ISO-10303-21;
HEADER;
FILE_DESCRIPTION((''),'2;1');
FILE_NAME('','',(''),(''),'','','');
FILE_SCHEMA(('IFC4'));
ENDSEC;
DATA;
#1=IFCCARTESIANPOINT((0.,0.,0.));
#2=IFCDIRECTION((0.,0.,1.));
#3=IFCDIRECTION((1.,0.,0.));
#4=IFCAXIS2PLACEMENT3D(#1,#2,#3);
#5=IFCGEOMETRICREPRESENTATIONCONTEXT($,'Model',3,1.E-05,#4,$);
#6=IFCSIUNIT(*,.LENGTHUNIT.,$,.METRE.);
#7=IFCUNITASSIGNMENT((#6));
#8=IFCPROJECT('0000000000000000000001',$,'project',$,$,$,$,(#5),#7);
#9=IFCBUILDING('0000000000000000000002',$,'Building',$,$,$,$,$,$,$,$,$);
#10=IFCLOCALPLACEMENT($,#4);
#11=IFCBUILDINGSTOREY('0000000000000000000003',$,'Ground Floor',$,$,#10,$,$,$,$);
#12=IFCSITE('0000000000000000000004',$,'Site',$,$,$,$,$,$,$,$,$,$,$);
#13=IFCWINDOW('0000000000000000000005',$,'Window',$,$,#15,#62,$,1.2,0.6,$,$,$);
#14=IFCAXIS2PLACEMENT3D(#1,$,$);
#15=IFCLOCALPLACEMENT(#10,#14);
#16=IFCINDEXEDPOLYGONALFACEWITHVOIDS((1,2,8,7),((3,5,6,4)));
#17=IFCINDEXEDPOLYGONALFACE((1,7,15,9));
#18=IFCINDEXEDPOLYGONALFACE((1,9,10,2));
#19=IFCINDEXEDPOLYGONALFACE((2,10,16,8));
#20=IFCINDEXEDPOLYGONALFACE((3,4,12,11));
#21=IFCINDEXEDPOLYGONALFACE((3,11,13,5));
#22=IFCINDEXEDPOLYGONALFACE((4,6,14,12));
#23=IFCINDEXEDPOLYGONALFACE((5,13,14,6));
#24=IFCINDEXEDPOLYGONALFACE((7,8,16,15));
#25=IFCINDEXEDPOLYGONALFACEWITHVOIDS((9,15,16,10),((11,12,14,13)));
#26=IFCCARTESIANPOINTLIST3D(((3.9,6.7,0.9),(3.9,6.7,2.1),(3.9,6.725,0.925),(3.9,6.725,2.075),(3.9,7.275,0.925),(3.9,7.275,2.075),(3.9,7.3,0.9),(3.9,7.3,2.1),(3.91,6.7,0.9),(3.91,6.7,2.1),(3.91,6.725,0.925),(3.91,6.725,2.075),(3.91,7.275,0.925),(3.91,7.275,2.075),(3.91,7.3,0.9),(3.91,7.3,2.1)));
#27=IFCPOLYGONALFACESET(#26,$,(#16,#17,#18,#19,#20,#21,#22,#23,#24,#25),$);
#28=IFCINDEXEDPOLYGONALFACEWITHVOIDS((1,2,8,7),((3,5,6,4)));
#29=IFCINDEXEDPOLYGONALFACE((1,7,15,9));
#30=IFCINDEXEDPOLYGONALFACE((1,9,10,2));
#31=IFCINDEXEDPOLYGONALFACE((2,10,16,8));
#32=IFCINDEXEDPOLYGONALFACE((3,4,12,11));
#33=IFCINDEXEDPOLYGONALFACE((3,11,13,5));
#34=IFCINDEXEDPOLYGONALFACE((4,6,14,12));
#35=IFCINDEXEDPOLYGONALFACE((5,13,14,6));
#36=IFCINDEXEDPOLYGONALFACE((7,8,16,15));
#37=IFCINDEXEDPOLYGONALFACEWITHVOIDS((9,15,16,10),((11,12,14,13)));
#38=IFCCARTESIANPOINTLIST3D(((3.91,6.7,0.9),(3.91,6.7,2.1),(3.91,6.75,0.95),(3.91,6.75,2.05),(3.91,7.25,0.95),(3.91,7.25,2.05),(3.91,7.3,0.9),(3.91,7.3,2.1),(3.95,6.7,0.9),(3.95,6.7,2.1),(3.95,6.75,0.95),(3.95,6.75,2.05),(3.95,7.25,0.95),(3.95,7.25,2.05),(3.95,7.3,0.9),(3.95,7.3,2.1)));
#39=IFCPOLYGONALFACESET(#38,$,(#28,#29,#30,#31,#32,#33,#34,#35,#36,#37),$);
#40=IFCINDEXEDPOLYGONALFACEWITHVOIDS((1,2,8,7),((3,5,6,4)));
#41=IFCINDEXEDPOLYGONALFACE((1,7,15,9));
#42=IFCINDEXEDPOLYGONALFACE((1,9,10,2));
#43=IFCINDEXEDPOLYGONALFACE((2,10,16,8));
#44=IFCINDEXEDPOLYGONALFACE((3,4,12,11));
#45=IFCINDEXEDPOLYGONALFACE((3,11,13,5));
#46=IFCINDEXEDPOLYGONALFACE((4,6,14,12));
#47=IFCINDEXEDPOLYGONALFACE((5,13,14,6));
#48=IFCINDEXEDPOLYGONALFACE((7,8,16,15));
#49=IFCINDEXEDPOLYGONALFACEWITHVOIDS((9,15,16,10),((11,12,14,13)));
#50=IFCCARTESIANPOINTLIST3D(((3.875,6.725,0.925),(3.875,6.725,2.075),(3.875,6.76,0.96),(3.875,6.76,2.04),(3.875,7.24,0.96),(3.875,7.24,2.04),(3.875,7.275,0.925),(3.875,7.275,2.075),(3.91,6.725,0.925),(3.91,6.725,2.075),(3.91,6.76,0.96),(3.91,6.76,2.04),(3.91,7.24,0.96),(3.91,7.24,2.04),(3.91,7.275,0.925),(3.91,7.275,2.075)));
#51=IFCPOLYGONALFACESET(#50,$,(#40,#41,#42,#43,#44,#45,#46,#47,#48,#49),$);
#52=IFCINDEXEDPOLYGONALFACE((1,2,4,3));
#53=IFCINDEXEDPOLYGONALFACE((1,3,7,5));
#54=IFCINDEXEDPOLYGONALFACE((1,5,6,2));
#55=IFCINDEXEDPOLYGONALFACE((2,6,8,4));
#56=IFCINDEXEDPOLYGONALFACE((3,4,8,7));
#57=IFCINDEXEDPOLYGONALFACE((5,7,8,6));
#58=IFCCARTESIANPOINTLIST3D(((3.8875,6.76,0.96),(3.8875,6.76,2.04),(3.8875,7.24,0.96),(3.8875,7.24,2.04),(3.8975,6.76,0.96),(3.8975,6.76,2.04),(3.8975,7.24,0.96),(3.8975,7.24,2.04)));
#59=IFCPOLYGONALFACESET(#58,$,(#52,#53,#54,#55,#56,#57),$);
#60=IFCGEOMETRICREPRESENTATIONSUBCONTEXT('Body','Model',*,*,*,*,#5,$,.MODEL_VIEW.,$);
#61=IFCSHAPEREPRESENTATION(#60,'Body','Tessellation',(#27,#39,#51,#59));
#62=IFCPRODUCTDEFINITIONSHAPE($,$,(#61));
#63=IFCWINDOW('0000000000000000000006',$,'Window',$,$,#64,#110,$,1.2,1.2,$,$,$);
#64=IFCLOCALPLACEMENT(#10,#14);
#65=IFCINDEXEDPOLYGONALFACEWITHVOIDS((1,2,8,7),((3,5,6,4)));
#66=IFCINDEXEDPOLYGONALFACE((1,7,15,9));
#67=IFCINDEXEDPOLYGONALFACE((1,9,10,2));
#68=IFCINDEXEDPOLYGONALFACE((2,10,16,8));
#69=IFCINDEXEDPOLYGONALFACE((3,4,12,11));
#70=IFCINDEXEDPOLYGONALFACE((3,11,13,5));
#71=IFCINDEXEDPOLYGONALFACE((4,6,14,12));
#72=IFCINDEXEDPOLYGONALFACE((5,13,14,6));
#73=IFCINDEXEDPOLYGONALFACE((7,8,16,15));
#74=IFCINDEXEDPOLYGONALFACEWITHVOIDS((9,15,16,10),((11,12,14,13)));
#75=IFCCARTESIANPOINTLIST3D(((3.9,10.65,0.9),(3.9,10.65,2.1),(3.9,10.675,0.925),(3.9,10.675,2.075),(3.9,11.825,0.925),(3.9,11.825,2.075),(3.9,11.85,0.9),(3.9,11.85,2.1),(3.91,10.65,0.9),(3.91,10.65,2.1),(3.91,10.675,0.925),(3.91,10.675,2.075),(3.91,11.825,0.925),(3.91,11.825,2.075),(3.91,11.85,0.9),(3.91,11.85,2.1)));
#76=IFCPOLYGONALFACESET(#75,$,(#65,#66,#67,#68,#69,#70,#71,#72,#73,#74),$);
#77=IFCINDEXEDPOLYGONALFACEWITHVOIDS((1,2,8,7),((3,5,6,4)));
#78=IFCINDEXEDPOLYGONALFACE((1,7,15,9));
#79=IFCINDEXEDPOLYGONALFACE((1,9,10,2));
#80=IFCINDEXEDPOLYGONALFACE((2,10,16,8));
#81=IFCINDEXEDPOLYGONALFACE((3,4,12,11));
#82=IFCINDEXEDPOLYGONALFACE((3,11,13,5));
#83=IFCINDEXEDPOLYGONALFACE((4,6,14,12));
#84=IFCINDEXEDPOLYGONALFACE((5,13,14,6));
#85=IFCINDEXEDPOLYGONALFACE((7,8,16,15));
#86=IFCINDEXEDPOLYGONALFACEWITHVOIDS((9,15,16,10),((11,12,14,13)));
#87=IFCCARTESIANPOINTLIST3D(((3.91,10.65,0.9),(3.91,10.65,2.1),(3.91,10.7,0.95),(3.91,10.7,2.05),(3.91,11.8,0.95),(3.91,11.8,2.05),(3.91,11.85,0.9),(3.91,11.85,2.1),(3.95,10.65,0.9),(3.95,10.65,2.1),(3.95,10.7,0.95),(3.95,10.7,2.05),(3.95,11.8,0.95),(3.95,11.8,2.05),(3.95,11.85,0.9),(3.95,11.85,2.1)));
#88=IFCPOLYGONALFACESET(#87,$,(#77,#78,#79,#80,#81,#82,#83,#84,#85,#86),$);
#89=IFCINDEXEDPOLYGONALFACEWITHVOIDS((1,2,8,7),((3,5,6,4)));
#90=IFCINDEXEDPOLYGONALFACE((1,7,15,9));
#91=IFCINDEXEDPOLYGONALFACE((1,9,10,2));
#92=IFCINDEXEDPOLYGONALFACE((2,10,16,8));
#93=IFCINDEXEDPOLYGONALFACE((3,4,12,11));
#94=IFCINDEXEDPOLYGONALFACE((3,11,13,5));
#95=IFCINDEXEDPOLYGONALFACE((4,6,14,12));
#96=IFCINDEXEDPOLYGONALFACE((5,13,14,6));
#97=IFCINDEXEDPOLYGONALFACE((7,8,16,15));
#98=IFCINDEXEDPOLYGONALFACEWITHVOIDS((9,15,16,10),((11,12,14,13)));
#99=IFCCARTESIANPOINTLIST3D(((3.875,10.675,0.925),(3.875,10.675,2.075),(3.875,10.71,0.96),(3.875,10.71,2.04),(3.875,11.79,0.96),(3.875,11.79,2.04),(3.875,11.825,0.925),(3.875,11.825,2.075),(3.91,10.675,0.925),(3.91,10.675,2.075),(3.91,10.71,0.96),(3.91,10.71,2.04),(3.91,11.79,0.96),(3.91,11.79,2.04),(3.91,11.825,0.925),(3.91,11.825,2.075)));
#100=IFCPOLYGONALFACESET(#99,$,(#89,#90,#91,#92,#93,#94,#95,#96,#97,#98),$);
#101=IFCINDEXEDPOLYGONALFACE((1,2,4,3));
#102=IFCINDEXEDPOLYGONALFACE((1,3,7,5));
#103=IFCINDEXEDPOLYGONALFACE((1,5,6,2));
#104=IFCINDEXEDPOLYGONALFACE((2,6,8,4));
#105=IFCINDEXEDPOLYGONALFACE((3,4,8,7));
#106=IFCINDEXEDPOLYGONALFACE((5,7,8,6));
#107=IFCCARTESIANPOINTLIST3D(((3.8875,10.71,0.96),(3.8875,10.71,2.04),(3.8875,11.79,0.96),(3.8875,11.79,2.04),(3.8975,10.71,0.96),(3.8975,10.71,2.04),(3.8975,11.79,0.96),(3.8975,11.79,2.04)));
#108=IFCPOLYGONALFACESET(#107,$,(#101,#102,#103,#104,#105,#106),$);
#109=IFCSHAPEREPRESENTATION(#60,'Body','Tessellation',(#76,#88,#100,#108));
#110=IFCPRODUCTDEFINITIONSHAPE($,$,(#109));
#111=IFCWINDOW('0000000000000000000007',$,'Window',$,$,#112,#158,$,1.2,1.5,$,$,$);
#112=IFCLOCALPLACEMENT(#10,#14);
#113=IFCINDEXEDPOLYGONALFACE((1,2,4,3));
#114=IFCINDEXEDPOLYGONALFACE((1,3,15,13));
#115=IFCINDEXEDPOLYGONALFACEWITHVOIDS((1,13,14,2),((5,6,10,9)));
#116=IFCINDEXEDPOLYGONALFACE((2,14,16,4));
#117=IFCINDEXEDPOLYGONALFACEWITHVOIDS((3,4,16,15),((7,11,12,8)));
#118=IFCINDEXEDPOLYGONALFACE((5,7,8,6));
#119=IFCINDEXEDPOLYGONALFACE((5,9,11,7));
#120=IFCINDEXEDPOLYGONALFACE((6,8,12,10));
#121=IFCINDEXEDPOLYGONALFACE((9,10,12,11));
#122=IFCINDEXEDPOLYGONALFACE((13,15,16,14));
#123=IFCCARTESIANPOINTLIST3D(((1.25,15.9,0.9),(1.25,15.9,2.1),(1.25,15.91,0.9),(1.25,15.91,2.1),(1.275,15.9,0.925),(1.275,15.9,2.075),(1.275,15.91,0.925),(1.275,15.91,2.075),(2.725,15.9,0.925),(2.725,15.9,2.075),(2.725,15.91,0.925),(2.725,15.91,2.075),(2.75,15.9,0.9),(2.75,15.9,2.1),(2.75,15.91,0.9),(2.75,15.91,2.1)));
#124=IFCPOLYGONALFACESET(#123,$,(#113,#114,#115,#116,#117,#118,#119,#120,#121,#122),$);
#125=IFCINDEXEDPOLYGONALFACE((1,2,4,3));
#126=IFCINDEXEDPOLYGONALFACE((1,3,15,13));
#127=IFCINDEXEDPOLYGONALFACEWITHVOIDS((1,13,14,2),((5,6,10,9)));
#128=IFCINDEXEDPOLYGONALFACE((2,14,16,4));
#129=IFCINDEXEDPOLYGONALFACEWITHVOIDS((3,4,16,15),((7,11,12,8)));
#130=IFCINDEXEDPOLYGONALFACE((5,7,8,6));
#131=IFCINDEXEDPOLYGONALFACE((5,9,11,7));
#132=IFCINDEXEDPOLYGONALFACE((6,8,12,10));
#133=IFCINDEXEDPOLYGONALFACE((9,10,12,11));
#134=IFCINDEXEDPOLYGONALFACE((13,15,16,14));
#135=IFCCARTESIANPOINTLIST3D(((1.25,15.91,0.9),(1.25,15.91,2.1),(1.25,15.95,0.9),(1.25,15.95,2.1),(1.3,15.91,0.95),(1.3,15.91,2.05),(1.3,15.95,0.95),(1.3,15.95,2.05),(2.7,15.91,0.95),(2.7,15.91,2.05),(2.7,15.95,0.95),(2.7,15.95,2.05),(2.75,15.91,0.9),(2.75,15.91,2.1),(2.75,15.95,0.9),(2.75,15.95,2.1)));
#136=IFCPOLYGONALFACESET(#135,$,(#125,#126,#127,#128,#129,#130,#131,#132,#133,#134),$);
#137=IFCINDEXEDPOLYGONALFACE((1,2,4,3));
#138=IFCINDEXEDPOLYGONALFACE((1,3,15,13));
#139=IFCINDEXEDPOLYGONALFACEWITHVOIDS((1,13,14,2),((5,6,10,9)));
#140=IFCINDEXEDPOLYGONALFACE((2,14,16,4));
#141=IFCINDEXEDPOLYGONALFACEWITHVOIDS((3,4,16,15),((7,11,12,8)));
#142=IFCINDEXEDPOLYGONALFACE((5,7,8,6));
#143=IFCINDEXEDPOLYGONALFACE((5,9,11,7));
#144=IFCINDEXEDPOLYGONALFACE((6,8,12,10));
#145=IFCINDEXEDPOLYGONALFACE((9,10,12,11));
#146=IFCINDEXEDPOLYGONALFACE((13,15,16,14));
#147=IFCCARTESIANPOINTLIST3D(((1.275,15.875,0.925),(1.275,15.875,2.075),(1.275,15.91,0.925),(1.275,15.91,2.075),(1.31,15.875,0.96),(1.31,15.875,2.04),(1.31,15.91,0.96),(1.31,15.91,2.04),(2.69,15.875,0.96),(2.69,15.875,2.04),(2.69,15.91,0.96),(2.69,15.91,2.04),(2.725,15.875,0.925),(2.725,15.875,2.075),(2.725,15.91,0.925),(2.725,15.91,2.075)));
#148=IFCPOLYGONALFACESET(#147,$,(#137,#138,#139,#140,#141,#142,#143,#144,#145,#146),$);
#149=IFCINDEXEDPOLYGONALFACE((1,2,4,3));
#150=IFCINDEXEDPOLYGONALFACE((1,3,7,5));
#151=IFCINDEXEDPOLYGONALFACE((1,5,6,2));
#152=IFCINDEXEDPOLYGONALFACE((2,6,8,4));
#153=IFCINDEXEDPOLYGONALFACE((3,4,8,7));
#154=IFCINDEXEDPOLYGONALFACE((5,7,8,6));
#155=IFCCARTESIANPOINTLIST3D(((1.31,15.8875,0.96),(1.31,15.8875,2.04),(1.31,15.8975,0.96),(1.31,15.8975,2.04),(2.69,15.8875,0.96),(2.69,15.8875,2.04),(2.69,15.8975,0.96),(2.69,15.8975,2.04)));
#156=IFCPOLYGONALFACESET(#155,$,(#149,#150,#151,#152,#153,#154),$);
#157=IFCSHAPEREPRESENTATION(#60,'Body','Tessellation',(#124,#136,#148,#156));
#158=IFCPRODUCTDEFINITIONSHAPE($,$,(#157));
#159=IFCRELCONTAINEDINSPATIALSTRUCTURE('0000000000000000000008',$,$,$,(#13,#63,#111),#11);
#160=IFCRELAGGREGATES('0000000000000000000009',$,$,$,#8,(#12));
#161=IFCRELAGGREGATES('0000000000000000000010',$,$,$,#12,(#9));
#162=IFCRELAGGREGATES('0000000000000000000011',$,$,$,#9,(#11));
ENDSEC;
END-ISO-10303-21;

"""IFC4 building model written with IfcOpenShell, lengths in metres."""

from ifc_helpers import new_model, si_unit, frame, origin_with_axes, place, context, subcontext, project, spatial, line, indexed_curve, outline, extrude, element, save


model = new_model("IFC4")

# Units and contexts
model_context = context("Model", 3, precision=1e-05, world=origin_with_axes())
body_context = subcontext(model_context, "Body", "Model", "MODEL_VIEW")
ifc_project = project(units=[si_unit("LENGTHUNIT", "METRE")], contexts=[model_context])

# Site, building, storey
site = spatial("IfcSite", under=ifc_project, Name="Site")
building = spatial("IfcBuilding", under=site, Name="Building")
storey_placement = place(None, origin_with_axes())
storey = spatial("IfcBuildingStorey", under=building, at=storey_placement, Name="Ground Floor")

# Windows
window_1_placement = place(storey_placement, frame((4.0, 6.7, 0.9), z_axis=(0.0, 0.0, 1.0), x_axis=(0.0, 1.0, 0.0)))
element("IfcWindow", 1, at=window_1_placement, inside=storey, Name="Window", OverallHeight=1.2, OverallWidth=0.6, context=body_context, shape_type="SweptSolid", body=[
    extrude(outline(indexed_curve([(0.0, 0.0), (0.6, 0.0), (0.6, 1.2), (0.0, 1.2)], segments=[line(1, 2, 3, 4, 1)]), holes=[indexed_curve([(0.025, 0.025), (0.575, 0.025), (0.575, 1.175), (0.025, 1.175)], segments=[line(1, 2, 3, 4, 1)])]), frame((0.0, 0.09, 0.0), z_axis=(0.0, -1.0, 0.0), x_axis=(1.0, 0.0, 0.0)), (0.0, 0.0, -1.0), 0.01),
    extrude(outline(indexed_curve([(0.0, 0.0), (0.6, 0.0), (0.6, 1.2), (0.0, 1.2)], segments=[line(1, 2, 3, 4, 1)]), holes=[indexed_curve([(0.05, 0.05), (0.55, 0.05), (0.55, 1.15), (0.05, 1.15)], segments=[line(1, 2, 3, 4, 1)])]), frame((0.0, 0.05, 0.0), z_axis=(0.0, -1.0, 0.0), x_axis=(1.0, 0.0, 0.0)), (0.0, 0.0, -1.0), 0.04),
    extrude(outline(indexed_curve([(0.0, 0.0), (0.55, 0.0), (0.55, 1.15), (0.0, 1.15)], segments=[line(1, 2, 3, 4, 1)]), holes=[indexed_curve([(0.035, 0.035), (0.515, 0.035), (0.515, 1.115), (0.035, 1.115)], segments=[line(1, 2, 3, 4, 1)])]), frame((0.025, 0.09, 0.025), z_axis=(0.0, -1.0, 0.0), x_axis=(1.0, 0.0, 0.0)), (0.0, 0.0, -1.0), 0.035),
    extrude(outline(indexed_curve([(0.035, 0.035), (0.515, 0.035), (0.515, 1.115), (0.035, 1.115)], segments=[line(1, 2, 3, 4, 1)])), frame((0.025, 0.1025, 0.025), z_axis=(0.0, -1.0, 0.0), x_axis=(1.0, 0.0, 0.0)), (0.0, 0.0, -1.0), 0.01),
])
window_2_placement = place(storey_placement, frame((4.0, 10.65, 0.9), z_axis=(0.0, 0.0, 1.0), x_axis=(0.0, 1.0, 0.0)))
element("IfcWindow", 2, at=window_2_placement, inside=storey, Name="Window", OverallHeight=1.2, OverallWidth=1.2, context=body_context, shape_type="SweptSolid", body=[
    extrude(outline(indexed_curve([(0.0, 0.0), (1.2, 0.0), (1.2, 1.2), (0.0, 1.2)], segments=[line(1, 2, 3, 4, 1)]), holes=[indexed_curve([(0.025, 0.025), (1.175, 0.025), (1.175, 1.175), (0.025, 1.175)], segments=[line(1, 2, 3, 4, 1)])]), frame((0.0, 0.09, 0.0), z_axis=(0.0, -1.0, 0.0), x_axis=(1.0, 0.0, 0.0)), (0.0, 0.0, -1.0), 0.01),
    extrude(outline(indexed_curve([(0.0, 0.0), (1.2, 0.0), (1.2, 1.2), (0.0, 1.2)], segments=[line(1, 2, 3, 4, 1)]), holes=[indexed_curve([(0.05, 0.05), (1.15, 0.05), (1.15, 1.15), (0.05, 1.15)], segments=[line(1, 2, 3, 4, 1)])]), frame((0.0, 0.05, 0.0), z_axis=(0.0, -1.0, 0.0), x_axis=(1.0, 0.0, 0.0)), (0.0, 0.0, -1.0), 0.04),
    extrude(outline(indexed_curve([(0.0, 0.0), (1.15, 0.0), (1.15, 1.15), (0.0, 1.15)], segments=[line(1, 2, 3, 4, 1)]), holes=[indexed_curve([(0.035, 0.035), (1.115, 0.035), (1.115, 1.115), (0.035, 1.115)], segments=[line(1, 2, 3, 4, 1)])]), frame((0.025, 0.09, 0.025), z_axis=(0.0, -1.0, 0.0), x_axis=(1.0, 0.0, 0.0)), (0.0, 0.0, -1.0), 0.035),
    extrude(outline(indexed_curve([(0.035, 0.035), (1.115, 0.035), (1.115, 1.115), (0.035, 1.115)], segments=[line(1, 2, 3, 4, 1)])), frame((0.025, 0.1025, 0.025), z_axis=(0.0, -1.0, 0.0), x_axis=(1.0, 0.0, 0.0)), (0.0, 0.0, -1.0), 0.01),
])
window_3_placement = place(storey_placement, frame((2.75, 16.0, 0.9), z_axis=(0.0, 0.0, 1.0), x_axis=(-1.0, 0.0, 0.0)))
element("IfcWindow", 3, at=window_3_placement, inside=storey, Name="Window", OverallHeight=1.2, OverallWidth=1.5, context=body_context, shape_type="SweptSolid", body=[
    extrude(outline(indexed_curve([(0.0, 0.0), (1.5, 0.0), (1.5, 1.2), (0.0, 1.2)], segments=[line(1, 2, 3, 4, 1)]), holes=[indexed_curve([(0.025, 0.025), (1.475, 0.025), (1.475, 1.175), (0.025, 1.175)], segments=[line(1, 2, 3, 4, 1)])]), frame((0.0, 0.09, 0.0), z_axis=(0.0, -1.0, 0.0), x_axis=(1.0, 0.0, 0.0)), (0.0, 0.0, -1.0), 0.01),
    extrude(outline(indexed_curve([(0.0, 0.0), (1.5, 0.0), (1.5, 1.2), (0.0, 1.2)], segments=[line(1, 2, 3, 4, 1)]), holes=[indexed_curve([(0.05, 0.05), (1.45, 0.05), (1.45, 1.15), (0.05, 1.15)], segments=[line(1, 2, 3, 4, 1)])]), frame((0.0, 0.05, 0.0), z_axis=(0.0, -1.0, 0.0), x_axis=(1.0, 0.0, 0.0)), (0.0, 0.0, -1.0), 0.04),
    extrude(outline(indexed_curve([(0.0, 0.0), (1.45, 0.0), (1.45, 1.15), (0.0, 1.15)], segments=[line(1, 2, 3, 4, 1)]), holes=[indexed_curve([(0.035, 0.035), (1.415, 0.035), (1.415, 1.115), (0.035, 1.115)], segments=[line(1, 2, 3, 4, 1)])]), frame((0.025, 0.09, 0.025), z_axis=(0.0, -1.0, 0.0), x_axis=(1.0, 0.0, 0.0)), (0.0, 0.0, -1.0), 0.035),
    extrude(outline(indexed_curve([(0.035, 0.035), (1.415, 0.035), (1.415, 1.115), (0.035, 1.115)], segments=[line(1, 2, 3, 4, 1)])), frame((0.025, 0.1025, 0.025), z_axis=(0.0, -1.0, 0.0), x_axis=(1.0, 0.0, 0.0)), (0.0, 0.0, -1.0), 0.01),
])

save(model, "model.ifc")
